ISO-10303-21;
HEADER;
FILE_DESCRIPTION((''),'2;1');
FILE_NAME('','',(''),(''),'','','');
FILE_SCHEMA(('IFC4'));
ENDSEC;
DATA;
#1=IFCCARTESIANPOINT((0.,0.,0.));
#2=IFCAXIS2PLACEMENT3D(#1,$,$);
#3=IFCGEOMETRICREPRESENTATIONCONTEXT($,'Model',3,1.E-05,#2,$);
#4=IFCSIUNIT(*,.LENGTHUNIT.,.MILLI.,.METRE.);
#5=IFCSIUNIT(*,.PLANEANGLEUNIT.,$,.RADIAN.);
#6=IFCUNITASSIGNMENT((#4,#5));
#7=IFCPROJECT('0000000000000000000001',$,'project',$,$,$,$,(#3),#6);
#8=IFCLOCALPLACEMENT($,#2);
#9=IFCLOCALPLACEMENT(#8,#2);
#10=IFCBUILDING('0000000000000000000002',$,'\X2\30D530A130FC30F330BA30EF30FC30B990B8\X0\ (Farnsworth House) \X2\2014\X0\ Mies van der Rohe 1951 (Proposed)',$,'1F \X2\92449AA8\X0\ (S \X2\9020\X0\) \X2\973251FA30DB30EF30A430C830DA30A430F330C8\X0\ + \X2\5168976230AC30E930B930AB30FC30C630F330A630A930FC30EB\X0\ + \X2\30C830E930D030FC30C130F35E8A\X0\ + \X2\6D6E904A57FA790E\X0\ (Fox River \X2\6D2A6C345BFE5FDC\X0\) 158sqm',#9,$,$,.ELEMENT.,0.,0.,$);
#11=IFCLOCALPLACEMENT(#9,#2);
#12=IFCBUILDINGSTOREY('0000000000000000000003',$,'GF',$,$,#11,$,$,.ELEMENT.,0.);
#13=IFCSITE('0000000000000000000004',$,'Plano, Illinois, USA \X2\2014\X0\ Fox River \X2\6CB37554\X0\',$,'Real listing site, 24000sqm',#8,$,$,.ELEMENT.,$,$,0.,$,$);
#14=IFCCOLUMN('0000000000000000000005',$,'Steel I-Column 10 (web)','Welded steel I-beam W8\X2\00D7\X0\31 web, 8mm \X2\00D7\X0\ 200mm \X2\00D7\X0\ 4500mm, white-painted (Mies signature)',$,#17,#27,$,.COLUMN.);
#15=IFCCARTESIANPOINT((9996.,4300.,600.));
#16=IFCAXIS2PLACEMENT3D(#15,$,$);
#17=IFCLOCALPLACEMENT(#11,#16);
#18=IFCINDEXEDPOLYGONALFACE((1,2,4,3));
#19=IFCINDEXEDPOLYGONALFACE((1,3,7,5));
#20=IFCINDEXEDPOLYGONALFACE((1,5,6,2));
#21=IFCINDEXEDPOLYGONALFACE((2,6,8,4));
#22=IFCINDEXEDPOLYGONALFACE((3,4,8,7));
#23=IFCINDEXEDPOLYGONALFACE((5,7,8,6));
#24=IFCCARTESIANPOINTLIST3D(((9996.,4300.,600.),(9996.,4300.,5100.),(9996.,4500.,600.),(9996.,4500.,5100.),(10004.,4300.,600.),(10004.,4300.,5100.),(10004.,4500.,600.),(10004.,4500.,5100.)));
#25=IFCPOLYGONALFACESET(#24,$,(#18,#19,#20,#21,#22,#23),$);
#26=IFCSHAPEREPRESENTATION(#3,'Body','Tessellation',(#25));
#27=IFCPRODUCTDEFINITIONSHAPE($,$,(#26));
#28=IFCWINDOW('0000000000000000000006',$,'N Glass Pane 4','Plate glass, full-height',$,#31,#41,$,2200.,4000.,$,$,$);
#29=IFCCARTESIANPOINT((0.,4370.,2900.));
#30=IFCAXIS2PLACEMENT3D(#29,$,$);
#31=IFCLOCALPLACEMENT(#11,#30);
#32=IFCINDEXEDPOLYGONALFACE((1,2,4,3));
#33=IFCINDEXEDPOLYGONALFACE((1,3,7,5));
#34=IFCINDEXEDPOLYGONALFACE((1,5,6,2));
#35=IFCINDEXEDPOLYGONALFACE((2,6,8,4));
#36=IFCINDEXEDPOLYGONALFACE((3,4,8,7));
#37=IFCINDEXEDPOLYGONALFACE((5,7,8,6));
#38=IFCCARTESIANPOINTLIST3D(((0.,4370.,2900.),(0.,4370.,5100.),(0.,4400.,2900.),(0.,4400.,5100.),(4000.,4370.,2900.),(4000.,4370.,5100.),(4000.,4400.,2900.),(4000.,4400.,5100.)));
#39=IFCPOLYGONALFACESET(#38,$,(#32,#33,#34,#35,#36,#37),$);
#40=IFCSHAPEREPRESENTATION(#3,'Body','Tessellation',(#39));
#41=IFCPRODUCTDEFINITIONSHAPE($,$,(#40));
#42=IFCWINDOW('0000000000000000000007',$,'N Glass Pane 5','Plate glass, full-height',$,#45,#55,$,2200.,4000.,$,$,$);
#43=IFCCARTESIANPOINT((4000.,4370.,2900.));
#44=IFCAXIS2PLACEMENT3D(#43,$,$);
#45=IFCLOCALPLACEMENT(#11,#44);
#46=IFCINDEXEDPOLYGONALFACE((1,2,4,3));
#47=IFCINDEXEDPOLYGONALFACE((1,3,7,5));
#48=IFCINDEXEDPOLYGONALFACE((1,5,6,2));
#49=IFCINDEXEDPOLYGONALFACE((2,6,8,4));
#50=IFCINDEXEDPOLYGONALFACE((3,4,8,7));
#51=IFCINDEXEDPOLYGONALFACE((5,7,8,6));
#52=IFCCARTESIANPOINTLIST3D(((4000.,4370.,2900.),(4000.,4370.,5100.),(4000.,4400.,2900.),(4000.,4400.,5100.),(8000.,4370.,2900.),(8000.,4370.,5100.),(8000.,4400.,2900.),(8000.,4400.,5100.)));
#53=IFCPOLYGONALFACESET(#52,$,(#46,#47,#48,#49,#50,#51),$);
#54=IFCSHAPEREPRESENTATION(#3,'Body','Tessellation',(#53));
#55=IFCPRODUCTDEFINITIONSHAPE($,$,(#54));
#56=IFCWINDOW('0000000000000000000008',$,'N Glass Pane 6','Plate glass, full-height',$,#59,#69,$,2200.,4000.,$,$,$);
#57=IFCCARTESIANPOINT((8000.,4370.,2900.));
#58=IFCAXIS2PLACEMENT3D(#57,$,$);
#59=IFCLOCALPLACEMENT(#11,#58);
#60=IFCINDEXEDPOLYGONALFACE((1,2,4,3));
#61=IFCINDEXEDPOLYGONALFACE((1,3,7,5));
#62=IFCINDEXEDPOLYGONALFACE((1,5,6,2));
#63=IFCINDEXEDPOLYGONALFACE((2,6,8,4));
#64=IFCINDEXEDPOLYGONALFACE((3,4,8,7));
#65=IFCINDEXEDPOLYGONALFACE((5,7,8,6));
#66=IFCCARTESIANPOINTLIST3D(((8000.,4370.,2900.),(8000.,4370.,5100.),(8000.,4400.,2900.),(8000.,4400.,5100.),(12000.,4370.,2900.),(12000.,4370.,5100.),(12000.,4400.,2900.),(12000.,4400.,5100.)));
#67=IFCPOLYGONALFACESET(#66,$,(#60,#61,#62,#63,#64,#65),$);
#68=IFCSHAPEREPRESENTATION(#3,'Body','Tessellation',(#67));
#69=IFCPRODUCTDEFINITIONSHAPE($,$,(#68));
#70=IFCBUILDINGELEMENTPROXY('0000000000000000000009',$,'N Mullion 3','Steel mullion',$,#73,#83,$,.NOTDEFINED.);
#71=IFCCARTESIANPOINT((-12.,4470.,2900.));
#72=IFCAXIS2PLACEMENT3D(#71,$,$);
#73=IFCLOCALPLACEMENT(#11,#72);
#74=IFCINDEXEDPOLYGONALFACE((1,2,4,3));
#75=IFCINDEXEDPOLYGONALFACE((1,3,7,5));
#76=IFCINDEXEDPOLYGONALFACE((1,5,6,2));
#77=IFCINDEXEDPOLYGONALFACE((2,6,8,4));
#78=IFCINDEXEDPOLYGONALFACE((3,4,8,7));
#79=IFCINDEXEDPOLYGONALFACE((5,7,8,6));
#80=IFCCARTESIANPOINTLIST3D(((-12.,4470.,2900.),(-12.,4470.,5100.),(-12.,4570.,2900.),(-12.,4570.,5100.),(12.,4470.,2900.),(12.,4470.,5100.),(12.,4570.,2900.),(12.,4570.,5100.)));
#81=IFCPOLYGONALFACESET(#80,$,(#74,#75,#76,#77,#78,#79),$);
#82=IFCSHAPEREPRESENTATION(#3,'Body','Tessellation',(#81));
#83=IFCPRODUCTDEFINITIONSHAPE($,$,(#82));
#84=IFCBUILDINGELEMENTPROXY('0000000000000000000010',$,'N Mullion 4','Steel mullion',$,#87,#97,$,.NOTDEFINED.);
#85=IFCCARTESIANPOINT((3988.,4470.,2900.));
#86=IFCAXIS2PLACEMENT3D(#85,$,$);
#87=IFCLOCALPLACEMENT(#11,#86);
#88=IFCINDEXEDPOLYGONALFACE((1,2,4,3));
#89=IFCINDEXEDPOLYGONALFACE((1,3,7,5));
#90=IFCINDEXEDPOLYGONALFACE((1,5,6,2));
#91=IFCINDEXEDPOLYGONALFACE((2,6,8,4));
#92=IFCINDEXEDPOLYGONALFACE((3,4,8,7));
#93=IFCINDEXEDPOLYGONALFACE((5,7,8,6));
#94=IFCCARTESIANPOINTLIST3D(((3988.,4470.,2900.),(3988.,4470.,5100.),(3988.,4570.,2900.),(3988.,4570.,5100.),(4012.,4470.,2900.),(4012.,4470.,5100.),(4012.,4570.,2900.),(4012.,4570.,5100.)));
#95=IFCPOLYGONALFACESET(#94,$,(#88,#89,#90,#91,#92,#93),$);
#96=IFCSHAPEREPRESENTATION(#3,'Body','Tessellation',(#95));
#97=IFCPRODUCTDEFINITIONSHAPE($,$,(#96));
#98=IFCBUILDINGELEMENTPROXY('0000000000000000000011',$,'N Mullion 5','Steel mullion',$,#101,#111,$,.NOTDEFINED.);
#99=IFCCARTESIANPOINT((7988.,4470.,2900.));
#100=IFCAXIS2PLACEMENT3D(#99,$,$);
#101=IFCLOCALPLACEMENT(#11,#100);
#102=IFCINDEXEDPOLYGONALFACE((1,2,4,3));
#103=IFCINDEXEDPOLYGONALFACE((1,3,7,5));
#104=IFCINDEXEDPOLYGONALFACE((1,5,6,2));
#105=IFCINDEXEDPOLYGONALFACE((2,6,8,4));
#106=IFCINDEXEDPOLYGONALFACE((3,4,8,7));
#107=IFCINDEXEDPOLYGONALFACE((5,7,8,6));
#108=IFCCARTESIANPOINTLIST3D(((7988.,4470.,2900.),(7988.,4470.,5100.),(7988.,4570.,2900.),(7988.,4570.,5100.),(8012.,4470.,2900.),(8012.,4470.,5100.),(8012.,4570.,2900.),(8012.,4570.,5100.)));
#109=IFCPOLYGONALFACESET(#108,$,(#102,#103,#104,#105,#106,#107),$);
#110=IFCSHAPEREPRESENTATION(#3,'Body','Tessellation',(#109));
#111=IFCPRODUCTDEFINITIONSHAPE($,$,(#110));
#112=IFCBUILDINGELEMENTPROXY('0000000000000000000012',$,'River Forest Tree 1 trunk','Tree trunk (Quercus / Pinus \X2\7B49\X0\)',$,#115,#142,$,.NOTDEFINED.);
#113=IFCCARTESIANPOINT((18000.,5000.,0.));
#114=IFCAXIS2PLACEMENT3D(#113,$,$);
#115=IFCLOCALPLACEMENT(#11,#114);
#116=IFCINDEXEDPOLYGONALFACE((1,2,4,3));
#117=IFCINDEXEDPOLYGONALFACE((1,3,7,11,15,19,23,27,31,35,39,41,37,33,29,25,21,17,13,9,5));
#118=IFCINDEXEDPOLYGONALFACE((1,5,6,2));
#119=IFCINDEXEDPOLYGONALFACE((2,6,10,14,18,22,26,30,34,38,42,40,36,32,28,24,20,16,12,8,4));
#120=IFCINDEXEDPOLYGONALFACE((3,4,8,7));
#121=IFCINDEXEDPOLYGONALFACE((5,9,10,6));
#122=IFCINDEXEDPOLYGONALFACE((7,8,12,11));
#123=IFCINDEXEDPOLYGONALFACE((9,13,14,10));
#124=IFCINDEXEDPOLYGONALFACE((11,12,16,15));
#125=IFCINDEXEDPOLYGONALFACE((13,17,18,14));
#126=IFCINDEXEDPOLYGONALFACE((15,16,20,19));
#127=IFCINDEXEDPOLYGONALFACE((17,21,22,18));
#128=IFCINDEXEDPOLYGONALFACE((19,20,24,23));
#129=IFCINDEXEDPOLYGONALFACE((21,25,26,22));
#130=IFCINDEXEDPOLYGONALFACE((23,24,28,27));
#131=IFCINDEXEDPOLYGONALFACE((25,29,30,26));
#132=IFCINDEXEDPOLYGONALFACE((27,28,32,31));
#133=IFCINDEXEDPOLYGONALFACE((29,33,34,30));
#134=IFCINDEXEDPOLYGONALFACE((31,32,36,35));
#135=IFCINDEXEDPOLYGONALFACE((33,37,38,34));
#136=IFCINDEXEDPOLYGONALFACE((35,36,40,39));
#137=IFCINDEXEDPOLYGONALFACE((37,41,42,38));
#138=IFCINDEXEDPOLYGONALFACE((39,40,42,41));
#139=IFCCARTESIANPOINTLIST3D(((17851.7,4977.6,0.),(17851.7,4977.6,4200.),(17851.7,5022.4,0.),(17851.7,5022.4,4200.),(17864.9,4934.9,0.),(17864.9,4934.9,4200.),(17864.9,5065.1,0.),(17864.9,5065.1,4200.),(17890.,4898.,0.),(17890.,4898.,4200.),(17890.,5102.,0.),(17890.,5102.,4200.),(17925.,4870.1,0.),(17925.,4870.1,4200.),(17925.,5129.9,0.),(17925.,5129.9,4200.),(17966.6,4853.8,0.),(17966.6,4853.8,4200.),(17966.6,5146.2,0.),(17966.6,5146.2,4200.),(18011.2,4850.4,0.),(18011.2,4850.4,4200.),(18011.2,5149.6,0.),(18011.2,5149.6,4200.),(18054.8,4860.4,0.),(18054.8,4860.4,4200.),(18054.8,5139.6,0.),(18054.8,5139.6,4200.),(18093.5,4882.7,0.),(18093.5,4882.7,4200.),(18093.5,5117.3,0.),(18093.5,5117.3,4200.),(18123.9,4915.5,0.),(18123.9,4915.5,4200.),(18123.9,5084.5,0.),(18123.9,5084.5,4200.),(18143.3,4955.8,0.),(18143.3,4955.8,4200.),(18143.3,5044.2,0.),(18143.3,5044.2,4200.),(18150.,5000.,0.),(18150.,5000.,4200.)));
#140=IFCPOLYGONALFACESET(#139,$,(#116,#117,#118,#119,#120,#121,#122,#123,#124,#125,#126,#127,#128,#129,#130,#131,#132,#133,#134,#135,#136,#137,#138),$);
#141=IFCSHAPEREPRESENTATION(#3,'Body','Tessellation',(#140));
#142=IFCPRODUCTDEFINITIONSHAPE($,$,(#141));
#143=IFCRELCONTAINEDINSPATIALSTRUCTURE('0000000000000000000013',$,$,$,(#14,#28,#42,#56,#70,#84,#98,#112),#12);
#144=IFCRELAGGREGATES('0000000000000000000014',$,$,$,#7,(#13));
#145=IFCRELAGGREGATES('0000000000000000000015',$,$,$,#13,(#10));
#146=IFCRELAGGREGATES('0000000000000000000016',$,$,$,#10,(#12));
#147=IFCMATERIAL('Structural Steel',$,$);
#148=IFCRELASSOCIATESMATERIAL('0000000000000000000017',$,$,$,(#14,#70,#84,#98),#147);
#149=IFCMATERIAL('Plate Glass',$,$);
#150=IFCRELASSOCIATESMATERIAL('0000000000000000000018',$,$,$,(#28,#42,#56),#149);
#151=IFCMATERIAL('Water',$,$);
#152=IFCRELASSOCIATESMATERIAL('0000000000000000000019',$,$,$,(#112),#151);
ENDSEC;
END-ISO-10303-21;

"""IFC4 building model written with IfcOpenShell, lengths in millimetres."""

from ifc_helpers import new_model, si_unit, frame, frame_2d, origin, origin_2d, place, context, project, spatial, rectangle, circle, extrude, material, element, save


model = new_model("IFC4")

# Units and contexts
model_context = context("Model", 3, precision=1e-05, world=origin())
ifc_project = project(units=[si_unit("LENGTHUNIT", "METRE", prefix="MILLI"), si_unit("PLANEANGLEUNIT", "RADIAN")], contexts=[model_context])

# Site, building, storey
site_placement = place(None, origin())
site = spatial("IfcSite", under=ifc_project, at=site_placement, Name="Plano, Illinois, USA — Fox River 河畔", ObjectType="Real listing site, 24000sqm", CompositionType="ELEMENT", RefElevation=0.0)
building_placement = place(site_placement, origin())
building = spatial("IfcBuilding", under=site, at=building_placement, Name="ファーンズワース邸 (Farnsworth House) — Mies van der Rohe 1951 (Proposed)", ObjectType="1F 鉄骨 (S 造) 露出ホワイトペイント + 全面ガラスカーテンウォール + トラバーチン床 + 浮遊基礎 (Fox River 洪水対応) 158sqm", CompositionType="ELEMENT", ElevationOfRefHeight=0.0, ElevationOfTerrain=0.0)
storey_placement = place(building_placement, origin())
storey = spatial("IfcBuildingStorey", under=building, at=storey_placement, Name="GF", CompositionType="ELEMENT", Elevation=0.0)

# Column
ifc_material_1 = material(Name="Structural Steel")
column_placement = place(storey_placement, frame((9996.0, 4300.0, 600.0)))
element("IfcColumn", 1, at=column_placement, inside=storey, material=ifc_material_1, Name="Steel I-Column 10 (web)", Description="Welded steel I-beam W8×31 web, 8mm × 200mm × 4500mm, white-painted (Mies signature)", PredefinedType="COLUMN", context=model_context, shape_type="SweptSolid", body=[
    extrude(rectangle(XDim=8.0, YDim=200.0, at=frame_2d((4.0, 100.0))), frame((9996.0, 4300.0, 600.0)), (0.0, 0.0, 1.0), 4500.0),
])

# Windows
ifc_material_2 = material(Name="Plate Glass")
window_1_placement = place(storey_placement, frame((0.0, 4370.0, 2900.0)))
element("IfcWindow", 2, at=window_1_placement, inside=storey, material=ifc_material_2, Name="N Glass Pane 4", Description="Plate glass, full-height", OverallHeight=2200.0, OverallWidth=4000.0, context=model_context, shape_type="SweptSolid", body=[
    extrude(rectangle(XDim=4000.0, YDim=30.0, at=frame_2d((2000.0, 15.0))), frame((0.0, 4370.0, 2900.0)), (0.0, 0.0, 1.0), 2200.0),
])
window_2_placement = place(storey_placement, frame((4000.0, 4370.0, 2900.0)))
element("IfcWindow", 3, at=window_2_placement, inside=storey, material=ifc_material_2, Name="N Glass Pane 5", Description="Plate glass, full-height", OverallHeight=2200.0, OverallWidth=4000.0, context=model_context, shape_type="SweptSolid", body=[
    extrude(rectangle(XDim=4000.0, YDim=30.0, at=frame_2d((2000.0, 15.0))), frame((4000.0, 4370.0, 2900.0)), (0.0, 0.0, 1.0), 2200.0),
])
window_3_placement = place(storey_placement, frame((8000.0, 4370.0, 2900.0)))
element("IfcWindow", 4, at=window_3_placement, inside=storey, material=ifc_material_2, Name="N Glass Pane 6", Description="Plate glass, full-height", OverallHeight=2200.0, OverallWidth=4000.0, context=model_context, shape_type="SweptSolid", body=[
    extrude(rectangle(XDim=4000.0, YDim=30.0, at=frame_2d((2000.0, 15.0))), frame((8000.0, 4370.0, 2900.0)), (0.0, 0.0, 1.0), 2200.0),
])

# Building element proxies
proxy_1_placement = place(storey_placement, frame((-12.0, 4470.0, 2900.0)))
element("IfcBuildingElementProxy", 5, at=proxy_1_placement, inside=storey, material=ifc_material_1, Name="N Mullion 3", Description="Steel mullion", PredefinedType="NOTDEFINED", context=model_context, shape_type="SweptSolid", body=[
    extrude(rectangle(XDim=24.0, YDim=100.0, at=frame_2d((12.0, 50.0))), frame((-12.0, 4470.0, 2900.0)), (0.0, 0.0, 1.0), 2200.0),
])
proxy_2_placement = place(storey_placement, frame((3988.0, 4470.0, 2900.0)))
element("IfcBuildingElementProxy", 6, at=proxy_2_placement, inside=storey, material=ifc_material_1, Name="N Mullion 4", Description="Steel mullion", PredefinedType="NOTDEFINED", context=model_context, shape_type="SweptSolid", body=[
    extrude(rectangle(XDim=24.0, YDim=100.0, at=frame_2d((12.0, 50.0))), frame((3988.0, 4470.0, 2900.0)), (0.0, 0.0, 1.0), 2200.0),
])
proxy_3_placement = place(storey_placement, frame((7988.0, 4470.0, 2900.0)))
element("IfcBuildingElementProxy", 7, at=proxy_3_placement, inside=storey, material=ifc_material_1, Name="N Mullion 5", Description="Steel mullion", PredefinedType="NOTDEFINED", context=model_context, shape_type="SweptSolid", body=[
    extrude(rectangle(XDim=24.0, YDim=100.0, at=frame_2d((12.0, 50.0))), frame((7988.0, 4470.0, 2900.0)), (0.0, 0.0, 1.0), 2200.0),
])
ifc_material_3 = material(Name="Water")
proxy_4_placement = place(storey_placement, frame((18000.0, 5000.0, 0.0)))
element("IfcBuildingElementProxy", 8, at=proxy_4_placement, inside=storey, material=ifc_material_3, Name="River Forest Tree 1 trunk", Description="Tree trunk (Quercus / Pinus 等)", PredefinedType="NOTDEFINED", context=model_context, shape_type="SweptSolid", body=[
    extrude(circle(Radius=150.0, at=origin_2d()), frame((18000.0, 5000.0, 0.0)), (0.0, 0.0, 1.0), 4200.0),
])

save(model, "model.ifc")
